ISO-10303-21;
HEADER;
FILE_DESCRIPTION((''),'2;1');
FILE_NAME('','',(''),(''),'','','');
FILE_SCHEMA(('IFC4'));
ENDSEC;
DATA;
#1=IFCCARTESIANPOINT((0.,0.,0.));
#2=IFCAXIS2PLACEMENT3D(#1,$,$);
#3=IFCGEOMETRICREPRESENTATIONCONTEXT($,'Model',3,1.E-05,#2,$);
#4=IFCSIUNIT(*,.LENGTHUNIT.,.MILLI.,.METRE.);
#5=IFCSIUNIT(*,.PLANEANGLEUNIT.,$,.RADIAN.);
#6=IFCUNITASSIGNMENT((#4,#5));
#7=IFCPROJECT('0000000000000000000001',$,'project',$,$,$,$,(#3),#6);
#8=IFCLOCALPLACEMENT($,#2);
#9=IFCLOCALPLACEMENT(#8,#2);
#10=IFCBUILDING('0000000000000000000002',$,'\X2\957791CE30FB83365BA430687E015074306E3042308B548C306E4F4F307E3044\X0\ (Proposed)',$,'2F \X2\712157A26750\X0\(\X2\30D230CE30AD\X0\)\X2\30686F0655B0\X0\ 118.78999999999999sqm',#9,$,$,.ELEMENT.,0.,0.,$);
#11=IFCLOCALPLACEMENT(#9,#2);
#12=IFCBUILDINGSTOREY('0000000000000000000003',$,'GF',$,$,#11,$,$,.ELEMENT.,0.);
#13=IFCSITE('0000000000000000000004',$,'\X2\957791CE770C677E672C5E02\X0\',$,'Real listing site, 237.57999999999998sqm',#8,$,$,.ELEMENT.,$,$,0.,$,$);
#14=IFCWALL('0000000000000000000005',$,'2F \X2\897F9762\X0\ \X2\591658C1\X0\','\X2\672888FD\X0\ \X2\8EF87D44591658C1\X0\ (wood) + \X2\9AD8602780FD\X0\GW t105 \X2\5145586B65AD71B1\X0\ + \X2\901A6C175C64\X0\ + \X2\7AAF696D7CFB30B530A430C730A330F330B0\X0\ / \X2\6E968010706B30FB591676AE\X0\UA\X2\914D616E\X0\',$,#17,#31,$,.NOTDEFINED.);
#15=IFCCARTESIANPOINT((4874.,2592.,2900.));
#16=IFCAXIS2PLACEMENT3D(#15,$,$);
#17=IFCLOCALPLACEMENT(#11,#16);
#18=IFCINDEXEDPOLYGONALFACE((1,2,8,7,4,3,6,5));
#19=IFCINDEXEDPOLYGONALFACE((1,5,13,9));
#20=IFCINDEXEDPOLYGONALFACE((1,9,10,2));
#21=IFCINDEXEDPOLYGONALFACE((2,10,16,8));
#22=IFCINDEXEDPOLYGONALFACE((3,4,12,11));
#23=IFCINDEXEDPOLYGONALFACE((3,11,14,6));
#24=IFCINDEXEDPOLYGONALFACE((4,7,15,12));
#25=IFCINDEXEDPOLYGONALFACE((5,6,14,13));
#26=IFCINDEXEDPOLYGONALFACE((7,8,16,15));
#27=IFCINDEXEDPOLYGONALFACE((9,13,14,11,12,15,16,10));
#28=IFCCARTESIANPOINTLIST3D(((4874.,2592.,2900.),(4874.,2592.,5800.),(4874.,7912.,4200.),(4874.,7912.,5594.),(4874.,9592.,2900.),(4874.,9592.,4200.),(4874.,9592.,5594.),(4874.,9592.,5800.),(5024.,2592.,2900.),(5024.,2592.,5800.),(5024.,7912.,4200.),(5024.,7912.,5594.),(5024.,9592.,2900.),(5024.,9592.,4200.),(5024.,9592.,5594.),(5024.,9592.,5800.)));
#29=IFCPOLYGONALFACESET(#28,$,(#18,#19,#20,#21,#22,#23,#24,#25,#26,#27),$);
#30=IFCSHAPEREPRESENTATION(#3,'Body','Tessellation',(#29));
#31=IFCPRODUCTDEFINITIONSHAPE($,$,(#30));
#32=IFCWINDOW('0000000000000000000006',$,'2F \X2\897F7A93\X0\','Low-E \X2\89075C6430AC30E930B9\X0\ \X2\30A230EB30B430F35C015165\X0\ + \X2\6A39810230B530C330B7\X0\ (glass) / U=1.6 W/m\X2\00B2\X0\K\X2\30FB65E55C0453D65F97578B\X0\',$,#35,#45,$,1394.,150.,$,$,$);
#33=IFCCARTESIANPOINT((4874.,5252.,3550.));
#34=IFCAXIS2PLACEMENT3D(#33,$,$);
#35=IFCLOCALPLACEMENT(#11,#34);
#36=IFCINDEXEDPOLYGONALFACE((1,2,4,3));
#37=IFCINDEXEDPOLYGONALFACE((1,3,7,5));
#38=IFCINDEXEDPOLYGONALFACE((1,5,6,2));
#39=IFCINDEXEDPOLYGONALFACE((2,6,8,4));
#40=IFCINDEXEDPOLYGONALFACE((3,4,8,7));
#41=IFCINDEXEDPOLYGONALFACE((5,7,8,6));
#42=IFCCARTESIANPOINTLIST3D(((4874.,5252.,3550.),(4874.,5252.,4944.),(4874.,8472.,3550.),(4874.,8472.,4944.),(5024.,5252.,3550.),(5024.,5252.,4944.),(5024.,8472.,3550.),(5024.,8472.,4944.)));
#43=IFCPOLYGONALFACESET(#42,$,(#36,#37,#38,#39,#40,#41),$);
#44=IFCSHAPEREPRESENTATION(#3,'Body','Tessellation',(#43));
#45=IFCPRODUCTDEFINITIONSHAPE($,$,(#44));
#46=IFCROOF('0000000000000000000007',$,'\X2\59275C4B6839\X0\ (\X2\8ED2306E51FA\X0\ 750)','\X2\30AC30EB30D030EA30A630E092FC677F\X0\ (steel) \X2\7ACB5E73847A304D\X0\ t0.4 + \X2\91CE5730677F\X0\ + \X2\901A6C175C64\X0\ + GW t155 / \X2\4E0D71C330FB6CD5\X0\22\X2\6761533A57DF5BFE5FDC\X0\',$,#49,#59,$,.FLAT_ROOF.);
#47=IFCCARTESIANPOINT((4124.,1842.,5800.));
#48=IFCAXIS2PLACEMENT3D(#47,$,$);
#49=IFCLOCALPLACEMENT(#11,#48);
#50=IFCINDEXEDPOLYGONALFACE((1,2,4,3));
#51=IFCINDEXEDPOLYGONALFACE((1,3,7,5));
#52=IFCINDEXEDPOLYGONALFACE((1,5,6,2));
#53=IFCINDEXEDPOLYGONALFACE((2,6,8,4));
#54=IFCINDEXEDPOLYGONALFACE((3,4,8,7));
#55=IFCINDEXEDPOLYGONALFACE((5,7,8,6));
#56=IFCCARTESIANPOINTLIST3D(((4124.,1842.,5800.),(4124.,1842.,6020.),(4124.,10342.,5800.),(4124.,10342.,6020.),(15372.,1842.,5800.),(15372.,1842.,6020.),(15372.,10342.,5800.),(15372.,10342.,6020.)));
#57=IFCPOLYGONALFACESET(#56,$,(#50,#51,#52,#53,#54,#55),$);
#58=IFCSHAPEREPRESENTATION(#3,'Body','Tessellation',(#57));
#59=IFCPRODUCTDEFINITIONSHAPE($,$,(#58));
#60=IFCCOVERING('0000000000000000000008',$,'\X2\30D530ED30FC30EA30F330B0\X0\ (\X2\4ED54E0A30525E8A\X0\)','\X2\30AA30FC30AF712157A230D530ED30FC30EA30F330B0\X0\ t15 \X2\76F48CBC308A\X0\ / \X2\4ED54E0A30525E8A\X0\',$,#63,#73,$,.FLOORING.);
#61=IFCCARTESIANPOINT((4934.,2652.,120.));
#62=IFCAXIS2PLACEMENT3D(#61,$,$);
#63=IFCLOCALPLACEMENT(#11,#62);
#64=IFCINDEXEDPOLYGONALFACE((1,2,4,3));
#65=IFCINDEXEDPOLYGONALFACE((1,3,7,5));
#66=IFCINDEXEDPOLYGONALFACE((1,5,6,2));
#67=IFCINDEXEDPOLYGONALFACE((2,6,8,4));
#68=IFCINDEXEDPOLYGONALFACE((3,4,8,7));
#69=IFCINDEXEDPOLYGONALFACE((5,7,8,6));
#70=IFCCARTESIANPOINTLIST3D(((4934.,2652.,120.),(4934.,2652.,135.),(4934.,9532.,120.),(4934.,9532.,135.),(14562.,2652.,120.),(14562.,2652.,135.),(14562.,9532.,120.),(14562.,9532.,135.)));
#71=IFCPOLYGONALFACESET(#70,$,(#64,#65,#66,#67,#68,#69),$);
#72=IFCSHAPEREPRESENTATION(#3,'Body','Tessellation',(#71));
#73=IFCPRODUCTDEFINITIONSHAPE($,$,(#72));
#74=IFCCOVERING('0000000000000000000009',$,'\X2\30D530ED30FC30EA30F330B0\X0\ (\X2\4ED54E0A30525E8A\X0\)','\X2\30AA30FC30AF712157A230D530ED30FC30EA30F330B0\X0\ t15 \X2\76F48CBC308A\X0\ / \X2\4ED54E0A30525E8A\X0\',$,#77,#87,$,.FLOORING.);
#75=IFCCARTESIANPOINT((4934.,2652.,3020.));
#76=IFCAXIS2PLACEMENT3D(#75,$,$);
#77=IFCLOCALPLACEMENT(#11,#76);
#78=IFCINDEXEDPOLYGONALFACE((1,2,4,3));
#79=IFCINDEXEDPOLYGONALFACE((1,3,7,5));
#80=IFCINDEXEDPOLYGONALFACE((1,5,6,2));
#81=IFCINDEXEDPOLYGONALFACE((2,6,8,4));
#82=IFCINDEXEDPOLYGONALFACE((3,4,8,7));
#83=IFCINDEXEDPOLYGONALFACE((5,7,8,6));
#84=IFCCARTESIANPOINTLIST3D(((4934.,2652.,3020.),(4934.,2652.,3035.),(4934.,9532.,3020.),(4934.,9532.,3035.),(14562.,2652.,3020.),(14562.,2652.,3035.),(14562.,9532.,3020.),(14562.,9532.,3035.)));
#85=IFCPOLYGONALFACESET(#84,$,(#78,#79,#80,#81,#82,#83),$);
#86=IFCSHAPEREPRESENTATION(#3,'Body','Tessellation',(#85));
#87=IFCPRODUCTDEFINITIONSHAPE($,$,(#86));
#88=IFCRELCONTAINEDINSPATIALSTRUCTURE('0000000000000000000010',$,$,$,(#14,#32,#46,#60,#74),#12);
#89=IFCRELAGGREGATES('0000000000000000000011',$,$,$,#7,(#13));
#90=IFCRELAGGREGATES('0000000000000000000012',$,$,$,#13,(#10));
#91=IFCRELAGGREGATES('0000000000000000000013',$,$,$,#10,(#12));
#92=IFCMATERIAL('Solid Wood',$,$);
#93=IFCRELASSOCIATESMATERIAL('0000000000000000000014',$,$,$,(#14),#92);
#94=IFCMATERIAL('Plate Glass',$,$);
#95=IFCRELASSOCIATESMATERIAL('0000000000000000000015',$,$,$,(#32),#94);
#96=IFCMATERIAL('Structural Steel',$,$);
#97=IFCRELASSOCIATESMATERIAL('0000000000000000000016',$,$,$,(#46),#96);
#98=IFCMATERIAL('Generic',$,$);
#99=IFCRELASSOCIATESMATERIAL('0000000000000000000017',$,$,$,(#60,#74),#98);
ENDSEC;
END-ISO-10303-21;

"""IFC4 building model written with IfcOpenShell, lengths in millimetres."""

from ifc_helpers import new_model, si_unit, frame, frame_2d, origin, place, context, project, spatial, rectangle, extrude, material, element, fill, save


model = new_model("IFC4")

# Units and contexts
model_context = context("Model", 3, precision=1e-05, world=origin())
ifc_project = project(units=[si_unit("LENGTHUNIT", "METRE", prefix="MILLI"), si_unit("PLANEANGLEUNIT", "RADIAN")], contexts=[model_context])

# Site, building, storey
site_placement = place(None, origin())
site = spatial("IfcSite", under=ifc_project, at=site_placement, Name="長野県松本市", ObjectType="Real listing site, 237.57999999999998sqm", CompositionType="ELEMENT", RefElevation=0.0)
building_placement = place(site_placement, origin())
building = spatial("IfcBuilding", under=site, at=building_placement, Name="長野・茶室と縁側のある和の住まい (Proposed)", ObjectType="2F 無垢材(ヒノキ)と漆喰 118.78999999999999sqm", CompositionType="ELEMENT", ElevationOfRefHeight=0.0, ElevationOfTerrain=0.0)
storey_placement = place(building_placement, origin())
storey = spatial("IfcBuildingStorey", under=building, at=storey_placement, Name="GF", CompositionType="ELEMENT", Elevation=0.0)

# Shared definitions
ifc_material_1 = material(Name="Solid Wood")

# Shared definitions
ifc_material_2 = material(Name="Plate Glass")

# Wall, opening, window
wall_1_placement = place(storey_placement, frame((4874.0, 2592.0, 2900.0)))
wall_1 = element("IfcWall", 1, at=wall_1_placement, inside=storey, material=ifc_material_1, Name="2F 西面 外壁", Description="木製 軸組外壁 (wood) + 高性能GW t105 充填断熱 + 通気層 + 窯業系サイディング / 準耐火・外皮UA配慮", PredefinedType="NOTDEFINED", context=model_context, shape_type="SweptSolid", body=[
    extrude(rectangle(XDim=150.0, YDim=7000.0, at=frame_2d((75.0, 3500.0))), frame((4874.0, 2592.0, 2900.0)), (0.0, 0.0, 1.0), 2900.0),
])
opening_1_placement = place(storey_placement, frame((4874.0, 5252.0, 3550.0)))
opening_1 = element("IfcOpeningElement", 2, at=opening_1_placement, cuts=wall_1, PredefinedType="NOTDEFINED", context=model_context, shape_type="SweptSolid", body=[
    extrude(rectangle(XDim=150.0, YDim=3220.0, at=frame_2d((75.0, 1610.0))), frame((4874.0, 5252.0, 3550.0)), (0.0, 0.0, 1.0), 1394.0),
])
window_1_placement = place(storey_placement, frame((4874.0, 5252.0, 3550.0)))
window_1 = element("IfcWindow", 3, at=window_1_placement, inside=storey, material=ifc_material_2, Name="2F 西窓", Description="Low-E 複層ガラス アルゴン封入 + 樹脂サッシ (glass) / U=1.6 W/m²K・日射取得型", OverallHeight=1394.0, OverallWidth=150.0, context=model_context, shape_type="SweptSolid", body=[
    extrude(rectangle(XDim=150.0, YDim=3220.0, at=frame_2d((75.0, 1610.0))), frame((4874.0, 5252.0, 3550.0)), (0.0, 0.0, 1.0), 1394.0),
])
fill(opening_1, window_1)

# Roof
ifc_material_3 = material(Name="Structural Steel")
roof_placement = place(storey_placement, frame((4124.0, 1842.0, 5800.0)))
element("IfcRoof", 4, at=roof_placement, inside=storey, material=ifc_material_3, Name="大屋根 (軒の出 750)", Description="ガルバリウム鋼板 (steel) 立平葺き t0.4 + 野地板 + 通気層 + GW t155 / 不燃・法22条区域対応", PredefinedType="FLAT_ROOF", context=model_context, shape_type="SweptSolid", body=[
    extrude(rectangle(XDim=11248.0, YDim=8500.0, at=frame_2d((5624.0, 4250.0))), frame((4124.0, 1842.0, 5800.0)), (0.0, 0.0, 1.0), 220.0),
])

# Coverings
ifc_material_4 = material(Name="Generic")
covering_1_placement = place(storey_placement, frame((4934.0, 2652.0, 120.0)))
element("IfcCovering", 5, at=covering_1_placement, inside=storey, material=ifc_material_4, Name="フローリング (仕上げ床)", Description="オーク無垢フローリング t15 直貼り / 仕上げ床", PredefinedType="FLOORING", context=model_context, shape_type="SweptSolid", body=[
    extrude(rectangle(XDim=9628.0, YDim=6880.0, at=frame_2d((4814.0, 3440.0))), frame((4934.0, 2652.0, 120.0)), (0.0, 0.0, 1.0), 15.0),
])
covering_2_placement = place(storey_placement, frame((4934.0, 2652.0, 3020.0)))
element("IfcCovering", 6, at=covering_2_placement, inside=storey, material=ifc_material_4, Name="フローリング (仕上げ床)", Description="オーク無垢フローリング t15 直貼り / 仕上げ床", PredefinedType="FLOORING", context=model_context, shape_type="SweptSolid", body=[
    extrude(rectangle(XDim=9628.0, YDim=6880.0, at=frame_2d((4814.0, 3440.0))), frame((4934.0, 2652.0, 3020.0)), (0.0, 0.0, 1.0), 15.0),
])

save(model, "model.ifc")
